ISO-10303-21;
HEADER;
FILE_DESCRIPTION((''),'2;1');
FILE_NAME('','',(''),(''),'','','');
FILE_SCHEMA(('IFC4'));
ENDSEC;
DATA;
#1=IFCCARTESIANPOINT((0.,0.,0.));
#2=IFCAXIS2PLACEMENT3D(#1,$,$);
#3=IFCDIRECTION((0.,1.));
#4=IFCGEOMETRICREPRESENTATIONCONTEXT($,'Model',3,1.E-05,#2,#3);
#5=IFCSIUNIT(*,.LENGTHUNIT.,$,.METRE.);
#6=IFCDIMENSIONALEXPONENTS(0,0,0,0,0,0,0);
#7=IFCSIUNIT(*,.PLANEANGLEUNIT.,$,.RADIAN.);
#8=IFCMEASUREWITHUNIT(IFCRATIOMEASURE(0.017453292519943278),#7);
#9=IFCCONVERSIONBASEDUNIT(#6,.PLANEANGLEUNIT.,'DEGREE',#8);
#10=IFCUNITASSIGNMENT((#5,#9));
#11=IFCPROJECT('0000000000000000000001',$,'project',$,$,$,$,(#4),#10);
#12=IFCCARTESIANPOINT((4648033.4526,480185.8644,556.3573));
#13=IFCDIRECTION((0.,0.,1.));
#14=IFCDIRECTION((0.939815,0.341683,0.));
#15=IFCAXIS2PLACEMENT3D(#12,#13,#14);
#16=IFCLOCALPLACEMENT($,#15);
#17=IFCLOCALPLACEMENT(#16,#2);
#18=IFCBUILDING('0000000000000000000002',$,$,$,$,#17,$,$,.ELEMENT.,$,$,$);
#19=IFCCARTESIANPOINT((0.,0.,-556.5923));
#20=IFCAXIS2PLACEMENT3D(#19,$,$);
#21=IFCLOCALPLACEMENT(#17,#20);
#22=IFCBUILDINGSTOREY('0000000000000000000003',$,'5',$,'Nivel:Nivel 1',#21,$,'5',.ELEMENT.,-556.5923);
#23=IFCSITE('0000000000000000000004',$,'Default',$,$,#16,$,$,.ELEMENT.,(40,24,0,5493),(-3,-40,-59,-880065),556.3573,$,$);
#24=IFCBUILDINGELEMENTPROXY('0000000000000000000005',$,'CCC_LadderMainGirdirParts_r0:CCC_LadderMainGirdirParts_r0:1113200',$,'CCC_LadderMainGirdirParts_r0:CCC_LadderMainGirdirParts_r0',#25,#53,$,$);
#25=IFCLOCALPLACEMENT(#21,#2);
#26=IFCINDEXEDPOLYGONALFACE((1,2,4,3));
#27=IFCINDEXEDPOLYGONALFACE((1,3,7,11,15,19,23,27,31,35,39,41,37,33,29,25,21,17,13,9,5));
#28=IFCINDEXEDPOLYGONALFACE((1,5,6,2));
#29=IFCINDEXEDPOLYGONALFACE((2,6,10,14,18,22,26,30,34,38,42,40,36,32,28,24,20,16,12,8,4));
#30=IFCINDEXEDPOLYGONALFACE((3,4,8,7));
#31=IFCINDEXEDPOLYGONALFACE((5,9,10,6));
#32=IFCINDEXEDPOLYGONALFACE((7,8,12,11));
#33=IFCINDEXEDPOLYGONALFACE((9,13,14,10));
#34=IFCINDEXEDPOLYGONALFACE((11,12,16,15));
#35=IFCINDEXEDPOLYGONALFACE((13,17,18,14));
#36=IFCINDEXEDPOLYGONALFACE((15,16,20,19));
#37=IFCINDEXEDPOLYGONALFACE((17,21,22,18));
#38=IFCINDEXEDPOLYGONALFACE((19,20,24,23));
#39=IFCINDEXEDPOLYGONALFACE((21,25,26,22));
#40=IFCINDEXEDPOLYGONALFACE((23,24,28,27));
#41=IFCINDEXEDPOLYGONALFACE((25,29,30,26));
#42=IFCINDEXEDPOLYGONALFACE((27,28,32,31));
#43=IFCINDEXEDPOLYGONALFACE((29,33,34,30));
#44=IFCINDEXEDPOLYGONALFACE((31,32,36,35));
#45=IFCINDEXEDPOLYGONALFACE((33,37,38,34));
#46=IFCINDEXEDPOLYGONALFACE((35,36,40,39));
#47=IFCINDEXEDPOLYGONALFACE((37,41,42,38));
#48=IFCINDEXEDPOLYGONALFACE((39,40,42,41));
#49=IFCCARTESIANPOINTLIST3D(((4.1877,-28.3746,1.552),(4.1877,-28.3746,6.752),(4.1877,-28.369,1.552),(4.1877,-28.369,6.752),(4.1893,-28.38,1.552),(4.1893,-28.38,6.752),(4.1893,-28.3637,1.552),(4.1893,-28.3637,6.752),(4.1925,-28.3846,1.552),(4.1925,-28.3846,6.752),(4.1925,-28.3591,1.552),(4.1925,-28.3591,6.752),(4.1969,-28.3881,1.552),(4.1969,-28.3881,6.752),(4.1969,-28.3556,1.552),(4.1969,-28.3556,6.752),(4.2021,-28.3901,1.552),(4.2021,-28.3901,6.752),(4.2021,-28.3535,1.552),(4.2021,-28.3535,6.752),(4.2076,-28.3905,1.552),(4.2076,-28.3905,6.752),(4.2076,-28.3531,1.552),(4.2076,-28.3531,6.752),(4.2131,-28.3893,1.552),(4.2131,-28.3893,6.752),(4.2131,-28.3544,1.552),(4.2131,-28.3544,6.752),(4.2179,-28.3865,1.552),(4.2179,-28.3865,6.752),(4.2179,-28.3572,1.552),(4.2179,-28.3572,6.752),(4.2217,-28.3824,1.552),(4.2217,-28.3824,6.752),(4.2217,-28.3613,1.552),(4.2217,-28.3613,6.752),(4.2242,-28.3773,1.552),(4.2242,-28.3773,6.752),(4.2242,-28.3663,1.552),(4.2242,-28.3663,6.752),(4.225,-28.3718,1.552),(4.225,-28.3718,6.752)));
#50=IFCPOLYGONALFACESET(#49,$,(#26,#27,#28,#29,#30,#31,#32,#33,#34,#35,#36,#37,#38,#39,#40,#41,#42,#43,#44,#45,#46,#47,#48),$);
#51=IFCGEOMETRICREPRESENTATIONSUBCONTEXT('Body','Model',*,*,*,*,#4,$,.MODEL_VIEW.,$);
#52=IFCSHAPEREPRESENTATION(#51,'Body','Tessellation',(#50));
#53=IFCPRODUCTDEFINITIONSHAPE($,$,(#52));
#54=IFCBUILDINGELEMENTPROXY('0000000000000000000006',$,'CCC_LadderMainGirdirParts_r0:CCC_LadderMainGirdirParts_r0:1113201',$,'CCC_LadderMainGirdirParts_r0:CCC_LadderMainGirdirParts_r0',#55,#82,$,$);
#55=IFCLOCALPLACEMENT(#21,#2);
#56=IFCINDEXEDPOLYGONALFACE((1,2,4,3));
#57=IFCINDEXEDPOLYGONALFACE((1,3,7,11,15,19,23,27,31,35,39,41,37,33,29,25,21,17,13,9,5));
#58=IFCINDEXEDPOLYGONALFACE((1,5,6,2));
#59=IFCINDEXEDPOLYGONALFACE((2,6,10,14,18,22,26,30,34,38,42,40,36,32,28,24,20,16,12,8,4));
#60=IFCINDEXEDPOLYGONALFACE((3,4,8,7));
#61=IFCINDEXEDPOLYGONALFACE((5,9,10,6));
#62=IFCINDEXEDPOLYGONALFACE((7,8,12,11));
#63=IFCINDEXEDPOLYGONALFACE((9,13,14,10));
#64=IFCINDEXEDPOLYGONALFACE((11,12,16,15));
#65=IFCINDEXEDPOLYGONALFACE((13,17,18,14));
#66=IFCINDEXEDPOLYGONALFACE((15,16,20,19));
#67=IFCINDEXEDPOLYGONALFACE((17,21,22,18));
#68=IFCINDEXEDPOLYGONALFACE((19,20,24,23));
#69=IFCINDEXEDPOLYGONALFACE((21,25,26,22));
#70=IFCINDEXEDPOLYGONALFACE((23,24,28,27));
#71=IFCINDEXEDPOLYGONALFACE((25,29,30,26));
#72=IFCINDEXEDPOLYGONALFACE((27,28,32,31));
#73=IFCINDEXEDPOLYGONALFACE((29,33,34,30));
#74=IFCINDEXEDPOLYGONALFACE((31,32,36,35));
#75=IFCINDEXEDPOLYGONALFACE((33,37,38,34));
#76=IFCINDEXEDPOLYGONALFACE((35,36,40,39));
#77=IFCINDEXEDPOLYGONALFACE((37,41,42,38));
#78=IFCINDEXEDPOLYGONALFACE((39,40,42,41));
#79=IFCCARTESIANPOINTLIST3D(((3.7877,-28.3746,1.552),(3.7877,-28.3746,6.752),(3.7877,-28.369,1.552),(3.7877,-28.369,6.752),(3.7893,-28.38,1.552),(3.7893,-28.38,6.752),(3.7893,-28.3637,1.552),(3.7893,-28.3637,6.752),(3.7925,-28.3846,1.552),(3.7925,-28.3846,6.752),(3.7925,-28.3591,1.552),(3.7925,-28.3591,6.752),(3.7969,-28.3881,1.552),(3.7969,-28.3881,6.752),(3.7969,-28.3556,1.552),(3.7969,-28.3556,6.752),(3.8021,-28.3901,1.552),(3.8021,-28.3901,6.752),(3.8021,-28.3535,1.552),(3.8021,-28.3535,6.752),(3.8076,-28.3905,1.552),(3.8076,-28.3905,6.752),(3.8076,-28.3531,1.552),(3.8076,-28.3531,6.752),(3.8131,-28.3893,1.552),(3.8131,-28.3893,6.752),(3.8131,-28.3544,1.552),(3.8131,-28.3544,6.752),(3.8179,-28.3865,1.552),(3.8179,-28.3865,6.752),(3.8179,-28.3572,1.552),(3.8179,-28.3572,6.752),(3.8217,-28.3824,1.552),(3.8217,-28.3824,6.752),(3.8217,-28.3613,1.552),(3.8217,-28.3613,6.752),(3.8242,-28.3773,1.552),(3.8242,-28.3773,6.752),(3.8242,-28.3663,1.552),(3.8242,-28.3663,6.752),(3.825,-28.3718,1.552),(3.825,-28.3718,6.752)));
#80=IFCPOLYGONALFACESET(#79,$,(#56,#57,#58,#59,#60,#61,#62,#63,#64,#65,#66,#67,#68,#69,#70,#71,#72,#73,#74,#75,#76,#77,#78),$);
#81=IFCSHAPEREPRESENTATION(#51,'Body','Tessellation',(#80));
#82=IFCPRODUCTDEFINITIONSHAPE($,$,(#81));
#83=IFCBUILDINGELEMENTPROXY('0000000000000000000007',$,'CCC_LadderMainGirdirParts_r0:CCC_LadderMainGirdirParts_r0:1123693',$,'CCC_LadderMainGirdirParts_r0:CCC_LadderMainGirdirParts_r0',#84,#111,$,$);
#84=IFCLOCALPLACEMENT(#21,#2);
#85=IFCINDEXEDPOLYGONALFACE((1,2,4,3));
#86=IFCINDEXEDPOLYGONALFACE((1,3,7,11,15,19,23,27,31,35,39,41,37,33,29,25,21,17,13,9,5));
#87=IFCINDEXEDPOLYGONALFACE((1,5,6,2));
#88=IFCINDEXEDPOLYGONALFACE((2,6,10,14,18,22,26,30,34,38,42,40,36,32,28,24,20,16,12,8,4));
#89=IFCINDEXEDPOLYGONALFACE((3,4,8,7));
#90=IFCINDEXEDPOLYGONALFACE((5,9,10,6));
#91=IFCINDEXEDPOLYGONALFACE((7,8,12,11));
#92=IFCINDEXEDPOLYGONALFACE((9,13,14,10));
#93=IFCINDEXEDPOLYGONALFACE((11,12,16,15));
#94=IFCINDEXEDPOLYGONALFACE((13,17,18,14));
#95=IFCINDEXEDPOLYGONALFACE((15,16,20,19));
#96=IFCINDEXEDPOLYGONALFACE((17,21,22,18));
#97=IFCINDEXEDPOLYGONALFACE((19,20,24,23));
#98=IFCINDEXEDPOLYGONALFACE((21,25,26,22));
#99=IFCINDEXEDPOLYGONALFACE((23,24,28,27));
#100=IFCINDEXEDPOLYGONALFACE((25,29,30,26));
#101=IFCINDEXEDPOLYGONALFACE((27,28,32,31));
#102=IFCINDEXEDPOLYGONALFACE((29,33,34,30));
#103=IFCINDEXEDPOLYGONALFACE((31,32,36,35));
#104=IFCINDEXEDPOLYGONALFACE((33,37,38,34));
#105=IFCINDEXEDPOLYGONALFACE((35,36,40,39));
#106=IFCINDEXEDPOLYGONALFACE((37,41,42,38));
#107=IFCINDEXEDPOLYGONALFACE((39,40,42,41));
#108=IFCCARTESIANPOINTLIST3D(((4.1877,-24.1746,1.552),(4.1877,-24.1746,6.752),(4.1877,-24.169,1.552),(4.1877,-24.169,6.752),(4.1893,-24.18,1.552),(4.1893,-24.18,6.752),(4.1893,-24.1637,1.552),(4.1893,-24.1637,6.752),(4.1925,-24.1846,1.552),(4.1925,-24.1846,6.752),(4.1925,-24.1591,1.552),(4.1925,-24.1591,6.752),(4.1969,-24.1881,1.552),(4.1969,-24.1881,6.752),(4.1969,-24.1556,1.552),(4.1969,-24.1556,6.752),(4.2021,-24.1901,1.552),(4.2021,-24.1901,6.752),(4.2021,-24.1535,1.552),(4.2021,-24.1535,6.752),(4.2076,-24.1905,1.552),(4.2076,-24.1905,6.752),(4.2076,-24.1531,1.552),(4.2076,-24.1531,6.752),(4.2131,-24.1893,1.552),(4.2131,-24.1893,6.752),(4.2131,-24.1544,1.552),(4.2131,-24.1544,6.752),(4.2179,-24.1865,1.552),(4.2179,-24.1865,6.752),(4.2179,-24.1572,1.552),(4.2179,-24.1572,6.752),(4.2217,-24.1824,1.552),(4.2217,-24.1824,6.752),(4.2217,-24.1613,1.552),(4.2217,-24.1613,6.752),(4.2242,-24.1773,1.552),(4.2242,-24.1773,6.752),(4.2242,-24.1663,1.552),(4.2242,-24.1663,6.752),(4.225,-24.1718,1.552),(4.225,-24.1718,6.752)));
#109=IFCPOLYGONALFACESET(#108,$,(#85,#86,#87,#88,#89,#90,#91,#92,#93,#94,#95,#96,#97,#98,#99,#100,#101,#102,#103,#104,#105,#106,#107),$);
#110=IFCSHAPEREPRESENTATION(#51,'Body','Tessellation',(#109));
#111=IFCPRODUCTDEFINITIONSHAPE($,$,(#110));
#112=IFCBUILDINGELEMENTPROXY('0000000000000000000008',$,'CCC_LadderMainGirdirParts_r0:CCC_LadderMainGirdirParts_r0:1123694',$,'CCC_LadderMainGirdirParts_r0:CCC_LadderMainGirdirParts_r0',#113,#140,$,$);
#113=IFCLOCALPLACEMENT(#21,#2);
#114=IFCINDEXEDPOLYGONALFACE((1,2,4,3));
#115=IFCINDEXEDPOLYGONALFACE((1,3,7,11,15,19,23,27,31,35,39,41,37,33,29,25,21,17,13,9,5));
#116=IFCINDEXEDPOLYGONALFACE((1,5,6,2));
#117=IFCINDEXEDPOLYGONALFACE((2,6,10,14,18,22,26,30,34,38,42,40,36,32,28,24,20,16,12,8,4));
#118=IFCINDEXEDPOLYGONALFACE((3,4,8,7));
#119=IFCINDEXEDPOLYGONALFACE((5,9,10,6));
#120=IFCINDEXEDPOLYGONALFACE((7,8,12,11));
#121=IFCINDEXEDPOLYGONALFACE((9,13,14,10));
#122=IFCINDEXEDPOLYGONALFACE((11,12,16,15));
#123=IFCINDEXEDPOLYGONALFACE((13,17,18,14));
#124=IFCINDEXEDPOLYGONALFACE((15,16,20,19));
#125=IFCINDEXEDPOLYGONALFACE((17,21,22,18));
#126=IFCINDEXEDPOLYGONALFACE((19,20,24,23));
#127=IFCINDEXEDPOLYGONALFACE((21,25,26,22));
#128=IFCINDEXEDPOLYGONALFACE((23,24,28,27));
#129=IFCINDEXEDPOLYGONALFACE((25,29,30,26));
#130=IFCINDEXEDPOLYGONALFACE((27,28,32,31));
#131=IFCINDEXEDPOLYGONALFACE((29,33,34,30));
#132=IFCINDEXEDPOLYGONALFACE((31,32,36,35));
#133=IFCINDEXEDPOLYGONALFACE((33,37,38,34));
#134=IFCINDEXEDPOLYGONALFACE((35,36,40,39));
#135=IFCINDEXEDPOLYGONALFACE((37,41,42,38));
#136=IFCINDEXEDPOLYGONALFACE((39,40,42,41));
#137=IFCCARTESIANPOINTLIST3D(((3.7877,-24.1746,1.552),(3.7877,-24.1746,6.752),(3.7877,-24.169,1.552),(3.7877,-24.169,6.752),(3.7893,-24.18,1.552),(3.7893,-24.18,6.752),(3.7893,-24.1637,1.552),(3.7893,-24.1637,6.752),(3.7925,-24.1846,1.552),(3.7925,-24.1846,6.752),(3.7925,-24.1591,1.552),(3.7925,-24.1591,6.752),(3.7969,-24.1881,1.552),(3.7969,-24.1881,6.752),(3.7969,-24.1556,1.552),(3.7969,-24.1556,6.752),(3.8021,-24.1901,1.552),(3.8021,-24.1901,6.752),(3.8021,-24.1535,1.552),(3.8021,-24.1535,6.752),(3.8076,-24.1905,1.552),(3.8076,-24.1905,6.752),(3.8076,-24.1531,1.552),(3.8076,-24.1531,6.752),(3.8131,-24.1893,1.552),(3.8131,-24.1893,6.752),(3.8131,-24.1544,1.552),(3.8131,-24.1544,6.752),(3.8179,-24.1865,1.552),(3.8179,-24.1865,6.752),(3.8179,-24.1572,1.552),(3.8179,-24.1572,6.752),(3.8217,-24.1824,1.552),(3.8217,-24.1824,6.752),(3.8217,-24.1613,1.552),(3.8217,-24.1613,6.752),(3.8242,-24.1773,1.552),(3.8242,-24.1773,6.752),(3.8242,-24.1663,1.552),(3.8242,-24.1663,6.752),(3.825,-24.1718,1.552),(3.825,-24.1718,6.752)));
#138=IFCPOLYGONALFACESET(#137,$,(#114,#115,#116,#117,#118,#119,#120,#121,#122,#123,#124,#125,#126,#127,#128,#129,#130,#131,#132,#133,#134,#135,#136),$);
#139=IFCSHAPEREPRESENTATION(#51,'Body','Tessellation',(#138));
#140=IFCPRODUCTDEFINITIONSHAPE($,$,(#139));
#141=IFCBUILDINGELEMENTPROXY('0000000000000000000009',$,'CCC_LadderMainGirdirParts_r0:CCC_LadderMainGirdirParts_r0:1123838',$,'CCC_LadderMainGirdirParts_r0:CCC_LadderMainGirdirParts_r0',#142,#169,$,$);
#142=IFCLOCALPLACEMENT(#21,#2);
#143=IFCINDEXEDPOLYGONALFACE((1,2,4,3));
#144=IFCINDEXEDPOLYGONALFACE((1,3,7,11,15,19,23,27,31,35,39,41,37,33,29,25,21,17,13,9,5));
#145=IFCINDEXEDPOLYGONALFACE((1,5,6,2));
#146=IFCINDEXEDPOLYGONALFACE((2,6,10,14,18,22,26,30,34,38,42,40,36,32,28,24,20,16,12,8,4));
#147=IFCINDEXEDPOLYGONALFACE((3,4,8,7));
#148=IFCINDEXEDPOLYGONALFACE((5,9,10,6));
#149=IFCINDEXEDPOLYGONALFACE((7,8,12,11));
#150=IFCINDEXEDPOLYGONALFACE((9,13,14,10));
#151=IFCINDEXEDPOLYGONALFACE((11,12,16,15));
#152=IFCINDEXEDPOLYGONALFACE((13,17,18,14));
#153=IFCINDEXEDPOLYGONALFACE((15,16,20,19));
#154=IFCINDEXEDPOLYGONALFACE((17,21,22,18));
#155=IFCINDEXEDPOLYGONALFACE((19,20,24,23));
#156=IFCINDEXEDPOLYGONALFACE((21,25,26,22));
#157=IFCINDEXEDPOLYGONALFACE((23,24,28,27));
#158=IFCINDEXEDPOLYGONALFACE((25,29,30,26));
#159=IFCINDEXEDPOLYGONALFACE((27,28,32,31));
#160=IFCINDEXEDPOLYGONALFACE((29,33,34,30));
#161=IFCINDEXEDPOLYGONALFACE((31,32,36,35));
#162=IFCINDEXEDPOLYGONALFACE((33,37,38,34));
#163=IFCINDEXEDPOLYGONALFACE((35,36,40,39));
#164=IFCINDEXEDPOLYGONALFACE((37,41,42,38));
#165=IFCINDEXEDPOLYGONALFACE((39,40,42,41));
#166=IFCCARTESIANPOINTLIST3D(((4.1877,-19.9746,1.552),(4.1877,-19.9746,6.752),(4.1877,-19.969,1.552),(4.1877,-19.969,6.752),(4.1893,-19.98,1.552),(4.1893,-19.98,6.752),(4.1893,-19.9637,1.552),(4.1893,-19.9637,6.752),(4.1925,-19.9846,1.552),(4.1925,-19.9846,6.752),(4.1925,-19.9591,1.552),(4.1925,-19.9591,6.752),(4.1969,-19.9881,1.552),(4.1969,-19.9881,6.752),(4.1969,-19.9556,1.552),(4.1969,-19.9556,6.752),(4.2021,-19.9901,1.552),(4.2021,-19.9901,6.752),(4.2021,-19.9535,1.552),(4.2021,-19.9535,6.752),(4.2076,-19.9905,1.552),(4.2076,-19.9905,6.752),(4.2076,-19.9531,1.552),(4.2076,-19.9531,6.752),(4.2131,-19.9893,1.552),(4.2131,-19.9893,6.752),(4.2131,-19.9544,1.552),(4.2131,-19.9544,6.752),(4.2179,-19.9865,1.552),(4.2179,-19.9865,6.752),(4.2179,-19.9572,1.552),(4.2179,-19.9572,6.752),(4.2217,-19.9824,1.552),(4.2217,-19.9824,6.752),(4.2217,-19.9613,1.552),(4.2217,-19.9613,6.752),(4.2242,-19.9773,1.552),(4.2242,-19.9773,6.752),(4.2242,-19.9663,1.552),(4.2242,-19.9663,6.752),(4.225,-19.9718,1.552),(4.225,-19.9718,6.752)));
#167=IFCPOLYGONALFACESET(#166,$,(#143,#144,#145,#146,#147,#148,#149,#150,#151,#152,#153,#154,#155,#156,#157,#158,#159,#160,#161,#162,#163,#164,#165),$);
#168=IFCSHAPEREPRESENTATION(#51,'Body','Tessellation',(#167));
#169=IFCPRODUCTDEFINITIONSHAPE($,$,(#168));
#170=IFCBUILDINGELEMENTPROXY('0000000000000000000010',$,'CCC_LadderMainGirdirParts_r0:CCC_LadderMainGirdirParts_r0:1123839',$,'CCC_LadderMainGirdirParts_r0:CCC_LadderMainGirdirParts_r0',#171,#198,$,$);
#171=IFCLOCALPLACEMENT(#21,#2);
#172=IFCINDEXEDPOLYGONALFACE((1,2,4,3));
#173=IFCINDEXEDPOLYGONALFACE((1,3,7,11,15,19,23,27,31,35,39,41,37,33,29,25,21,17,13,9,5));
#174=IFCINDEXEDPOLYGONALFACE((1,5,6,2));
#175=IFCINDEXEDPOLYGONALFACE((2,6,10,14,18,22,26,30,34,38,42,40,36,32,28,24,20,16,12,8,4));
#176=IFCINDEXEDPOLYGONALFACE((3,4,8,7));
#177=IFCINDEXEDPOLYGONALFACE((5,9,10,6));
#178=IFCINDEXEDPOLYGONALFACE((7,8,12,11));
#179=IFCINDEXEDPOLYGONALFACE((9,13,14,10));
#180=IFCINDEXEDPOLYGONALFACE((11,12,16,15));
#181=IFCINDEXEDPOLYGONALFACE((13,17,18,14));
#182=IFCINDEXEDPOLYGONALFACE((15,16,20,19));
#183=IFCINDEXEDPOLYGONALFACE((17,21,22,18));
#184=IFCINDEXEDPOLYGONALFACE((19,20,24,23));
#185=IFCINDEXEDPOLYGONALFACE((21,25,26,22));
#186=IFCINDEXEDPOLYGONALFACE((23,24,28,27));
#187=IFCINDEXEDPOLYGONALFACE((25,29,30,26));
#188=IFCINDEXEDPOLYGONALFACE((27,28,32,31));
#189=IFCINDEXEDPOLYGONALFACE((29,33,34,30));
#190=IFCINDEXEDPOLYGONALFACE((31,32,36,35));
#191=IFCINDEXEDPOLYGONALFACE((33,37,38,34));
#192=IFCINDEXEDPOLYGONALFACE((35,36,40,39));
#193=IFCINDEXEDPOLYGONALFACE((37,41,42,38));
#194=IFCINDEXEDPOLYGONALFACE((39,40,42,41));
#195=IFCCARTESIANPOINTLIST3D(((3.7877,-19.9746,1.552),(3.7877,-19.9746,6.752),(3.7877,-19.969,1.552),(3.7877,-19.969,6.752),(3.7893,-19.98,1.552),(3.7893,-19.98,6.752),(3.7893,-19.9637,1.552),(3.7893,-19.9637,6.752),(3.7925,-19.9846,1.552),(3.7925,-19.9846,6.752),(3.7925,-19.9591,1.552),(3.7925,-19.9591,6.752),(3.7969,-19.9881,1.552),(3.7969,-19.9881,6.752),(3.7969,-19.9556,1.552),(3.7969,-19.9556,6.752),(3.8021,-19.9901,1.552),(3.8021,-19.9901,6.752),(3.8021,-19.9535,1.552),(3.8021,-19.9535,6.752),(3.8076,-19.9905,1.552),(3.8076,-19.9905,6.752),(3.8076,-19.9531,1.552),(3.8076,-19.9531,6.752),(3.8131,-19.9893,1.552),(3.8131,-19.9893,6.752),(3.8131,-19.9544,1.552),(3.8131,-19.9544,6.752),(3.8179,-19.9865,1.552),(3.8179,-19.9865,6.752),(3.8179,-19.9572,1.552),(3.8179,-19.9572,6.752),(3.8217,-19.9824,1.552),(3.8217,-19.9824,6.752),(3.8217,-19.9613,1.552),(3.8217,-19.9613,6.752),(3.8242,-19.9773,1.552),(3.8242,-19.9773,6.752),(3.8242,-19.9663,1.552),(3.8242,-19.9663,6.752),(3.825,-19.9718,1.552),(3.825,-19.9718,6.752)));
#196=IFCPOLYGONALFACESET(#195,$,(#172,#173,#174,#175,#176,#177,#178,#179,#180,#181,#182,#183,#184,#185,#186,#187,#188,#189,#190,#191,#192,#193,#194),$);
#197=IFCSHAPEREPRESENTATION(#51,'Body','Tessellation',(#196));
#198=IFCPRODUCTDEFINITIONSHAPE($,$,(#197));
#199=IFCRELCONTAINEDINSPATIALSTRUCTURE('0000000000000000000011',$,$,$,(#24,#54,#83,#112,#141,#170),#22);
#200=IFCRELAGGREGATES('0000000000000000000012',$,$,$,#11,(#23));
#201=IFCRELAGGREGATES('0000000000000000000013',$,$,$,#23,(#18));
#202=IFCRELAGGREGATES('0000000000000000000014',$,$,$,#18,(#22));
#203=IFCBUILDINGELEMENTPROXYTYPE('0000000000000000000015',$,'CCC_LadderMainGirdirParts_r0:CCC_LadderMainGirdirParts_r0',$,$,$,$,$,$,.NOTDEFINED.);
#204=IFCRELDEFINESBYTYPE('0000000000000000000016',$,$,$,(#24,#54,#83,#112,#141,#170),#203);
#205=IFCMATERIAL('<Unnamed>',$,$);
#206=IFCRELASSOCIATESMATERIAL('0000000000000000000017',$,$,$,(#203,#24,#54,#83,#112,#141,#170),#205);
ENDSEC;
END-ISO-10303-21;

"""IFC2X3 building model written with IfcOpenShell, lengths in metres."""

from ifc_helpers import new_model, entity, si_unit, converted_unit, direction, frame, frame_2d, origin, place, context, subcontext, project, spatial, circle, extrude, source, transform, mapped, material, type_object, type_shapes, element, save


model = new_model("IFC2X3")

# Units and contexts
model_context = context("Model", 3, precision=1e-05, world=origin(), true_north=direction((0.0, 1.0)))
body_context = subcontext(model_context, "Body", "Model", "MODEL_VIEW")
ifc_project = project(units=[si_unit("LENGTHUNIT", "METRE"), converted_unit("PLANEANGLEUNIT", "DEGREE", entity("IfcRatioMeasure", 0.017453292519943278), si_unit("PLANEANGLEUNIT", "RADIAN"), dimensions=[0, 0, 0, 0, 0, 0, 0])], contexts=[model_context])

# Site, building, storey
site_placement = place(None, frame((4648033.4526, 480185.8644, 556.3573), z_axis=(0.0, 0.0, 1.0), x_axis=(0.939815, 0.341683, 0.0)))
site = spatial("IfcSite", under=ifc_project, at=site_placement, Name="Default", CompositionType="ELEMENT", RefLatitude=(40, 24, 0, 5493), RefLongitude=(-3, -40, -59, -880065), RefElevation=556.3573)
building_placement = place(site_placement, origin())
building = spatial("IfcBuilding", under=site, at=building_placement, CompositionType="ELEMENT")
storey_placement = place(building_placement, frame((0.0, 0.0, -556.5923)))
storey = spatial("IfcBuildingStorey", under=building, at=storey_placement, Name="5", ObjectType="Nivel:Nivel 1", LongName="5", CompositionType="ELEMENT", Elevation=-556.5923)

# Building element proxies
ifc_material_1 = material(Name="<Unnamed>")
building_element_proxy_type_1 = type_object("IfcBuildingElementProxyType", Name="CCC_LadderMainGirdirParts_r0:CCC_LadderMainGirdirParts_r0", PredefinedType="NOTDEFINED", material=ifc_material_1)
shared_shape_1 = source(origin(), body_context, "Body", "SweptSolid", [
    extrude(circle(Radius=0.0188, at=frame_2d((0.0, 0.0), x_axis=(1.0, 0.0))), frame((0.0, 0.0, 0.0), z_axis=(0.0, 0.0, 1.0), x_axis=(-1.0, 0.0, 0.0)), (0.0, 0.0, 1.0), 5.2),
])
type_shapes(building_element_proxy_type_1, [shared_shape_1])
for number, where, z_axis, x_axis, name in (
    (1, (4.2062, -28.3718, 1.552), (0.0, 0.0, 1.0), (-1.0, 0.0, 0.0), "CCC_LadderMainGirdirParts_r0:CCC_LadderMainGirdirParts_r0:1113200"),
    (2, (3.8062, -28.3718, 1.552), (0.0, 0.0, 1.0), (-1.0, 0.0, 0.0), "CCC_LadderMainGirdirParts_r0:CCC_LadderMainGirdirParts_r0:1113201"),
    (3, (4.2062, -24.1718, 1.552), (0.0, 0.0, 1.0), (-1.0, 0.0, 0.0), "CCC_LadderMainGirdirParts_r0:CCC_LadderMainGirdirParts_r0:1123693"),
    (4, (3.8062, -24.1718, 1.552), (0.0, 0.0, 1.0), (-1.0, 0.0, 0.0), "CCC_LadderMainGirdirParts_r0:CCC_LadderMainGirdirParts_r0:1123694"),
    (5, (4.2062, -19.9718, 1.552), (0.0, 0.0, 1.0), (-1.0, 0.0, 0.0), "CCC_LadderMainGirdirParts_r0:CCC_LadderMainGirdirParts_r0:1123838"),
    (6, (3.8062, -19.9718, 1.552), (0.0, 0.0, 1.0), (-1.0, 0.0, 0.0), "CCC_LadderMainGirdirParts_r0:CCC_LadderMainGirdirParts_r0:1123839"),
):
    element("IfcBuildingElementProxy", number, at=place(storey_placement, frame(where, z_axis=z_axis, x_axis=x_axis)), inside=storey, type_object=building_element_proxy_type_1, material=ifc_material_1, Name=name, ObjectType="CCC_LadderMainGirdirParts_r0:CCC_LadderMainGirdirParts_r0", context=body_context, shape_type="MappedRepresentation", body=[
        mapped(shared_shape_1, transform((0.0, 0.0, 0.0), scale=1.0)),
    ])

save(model, "model.ifc")
